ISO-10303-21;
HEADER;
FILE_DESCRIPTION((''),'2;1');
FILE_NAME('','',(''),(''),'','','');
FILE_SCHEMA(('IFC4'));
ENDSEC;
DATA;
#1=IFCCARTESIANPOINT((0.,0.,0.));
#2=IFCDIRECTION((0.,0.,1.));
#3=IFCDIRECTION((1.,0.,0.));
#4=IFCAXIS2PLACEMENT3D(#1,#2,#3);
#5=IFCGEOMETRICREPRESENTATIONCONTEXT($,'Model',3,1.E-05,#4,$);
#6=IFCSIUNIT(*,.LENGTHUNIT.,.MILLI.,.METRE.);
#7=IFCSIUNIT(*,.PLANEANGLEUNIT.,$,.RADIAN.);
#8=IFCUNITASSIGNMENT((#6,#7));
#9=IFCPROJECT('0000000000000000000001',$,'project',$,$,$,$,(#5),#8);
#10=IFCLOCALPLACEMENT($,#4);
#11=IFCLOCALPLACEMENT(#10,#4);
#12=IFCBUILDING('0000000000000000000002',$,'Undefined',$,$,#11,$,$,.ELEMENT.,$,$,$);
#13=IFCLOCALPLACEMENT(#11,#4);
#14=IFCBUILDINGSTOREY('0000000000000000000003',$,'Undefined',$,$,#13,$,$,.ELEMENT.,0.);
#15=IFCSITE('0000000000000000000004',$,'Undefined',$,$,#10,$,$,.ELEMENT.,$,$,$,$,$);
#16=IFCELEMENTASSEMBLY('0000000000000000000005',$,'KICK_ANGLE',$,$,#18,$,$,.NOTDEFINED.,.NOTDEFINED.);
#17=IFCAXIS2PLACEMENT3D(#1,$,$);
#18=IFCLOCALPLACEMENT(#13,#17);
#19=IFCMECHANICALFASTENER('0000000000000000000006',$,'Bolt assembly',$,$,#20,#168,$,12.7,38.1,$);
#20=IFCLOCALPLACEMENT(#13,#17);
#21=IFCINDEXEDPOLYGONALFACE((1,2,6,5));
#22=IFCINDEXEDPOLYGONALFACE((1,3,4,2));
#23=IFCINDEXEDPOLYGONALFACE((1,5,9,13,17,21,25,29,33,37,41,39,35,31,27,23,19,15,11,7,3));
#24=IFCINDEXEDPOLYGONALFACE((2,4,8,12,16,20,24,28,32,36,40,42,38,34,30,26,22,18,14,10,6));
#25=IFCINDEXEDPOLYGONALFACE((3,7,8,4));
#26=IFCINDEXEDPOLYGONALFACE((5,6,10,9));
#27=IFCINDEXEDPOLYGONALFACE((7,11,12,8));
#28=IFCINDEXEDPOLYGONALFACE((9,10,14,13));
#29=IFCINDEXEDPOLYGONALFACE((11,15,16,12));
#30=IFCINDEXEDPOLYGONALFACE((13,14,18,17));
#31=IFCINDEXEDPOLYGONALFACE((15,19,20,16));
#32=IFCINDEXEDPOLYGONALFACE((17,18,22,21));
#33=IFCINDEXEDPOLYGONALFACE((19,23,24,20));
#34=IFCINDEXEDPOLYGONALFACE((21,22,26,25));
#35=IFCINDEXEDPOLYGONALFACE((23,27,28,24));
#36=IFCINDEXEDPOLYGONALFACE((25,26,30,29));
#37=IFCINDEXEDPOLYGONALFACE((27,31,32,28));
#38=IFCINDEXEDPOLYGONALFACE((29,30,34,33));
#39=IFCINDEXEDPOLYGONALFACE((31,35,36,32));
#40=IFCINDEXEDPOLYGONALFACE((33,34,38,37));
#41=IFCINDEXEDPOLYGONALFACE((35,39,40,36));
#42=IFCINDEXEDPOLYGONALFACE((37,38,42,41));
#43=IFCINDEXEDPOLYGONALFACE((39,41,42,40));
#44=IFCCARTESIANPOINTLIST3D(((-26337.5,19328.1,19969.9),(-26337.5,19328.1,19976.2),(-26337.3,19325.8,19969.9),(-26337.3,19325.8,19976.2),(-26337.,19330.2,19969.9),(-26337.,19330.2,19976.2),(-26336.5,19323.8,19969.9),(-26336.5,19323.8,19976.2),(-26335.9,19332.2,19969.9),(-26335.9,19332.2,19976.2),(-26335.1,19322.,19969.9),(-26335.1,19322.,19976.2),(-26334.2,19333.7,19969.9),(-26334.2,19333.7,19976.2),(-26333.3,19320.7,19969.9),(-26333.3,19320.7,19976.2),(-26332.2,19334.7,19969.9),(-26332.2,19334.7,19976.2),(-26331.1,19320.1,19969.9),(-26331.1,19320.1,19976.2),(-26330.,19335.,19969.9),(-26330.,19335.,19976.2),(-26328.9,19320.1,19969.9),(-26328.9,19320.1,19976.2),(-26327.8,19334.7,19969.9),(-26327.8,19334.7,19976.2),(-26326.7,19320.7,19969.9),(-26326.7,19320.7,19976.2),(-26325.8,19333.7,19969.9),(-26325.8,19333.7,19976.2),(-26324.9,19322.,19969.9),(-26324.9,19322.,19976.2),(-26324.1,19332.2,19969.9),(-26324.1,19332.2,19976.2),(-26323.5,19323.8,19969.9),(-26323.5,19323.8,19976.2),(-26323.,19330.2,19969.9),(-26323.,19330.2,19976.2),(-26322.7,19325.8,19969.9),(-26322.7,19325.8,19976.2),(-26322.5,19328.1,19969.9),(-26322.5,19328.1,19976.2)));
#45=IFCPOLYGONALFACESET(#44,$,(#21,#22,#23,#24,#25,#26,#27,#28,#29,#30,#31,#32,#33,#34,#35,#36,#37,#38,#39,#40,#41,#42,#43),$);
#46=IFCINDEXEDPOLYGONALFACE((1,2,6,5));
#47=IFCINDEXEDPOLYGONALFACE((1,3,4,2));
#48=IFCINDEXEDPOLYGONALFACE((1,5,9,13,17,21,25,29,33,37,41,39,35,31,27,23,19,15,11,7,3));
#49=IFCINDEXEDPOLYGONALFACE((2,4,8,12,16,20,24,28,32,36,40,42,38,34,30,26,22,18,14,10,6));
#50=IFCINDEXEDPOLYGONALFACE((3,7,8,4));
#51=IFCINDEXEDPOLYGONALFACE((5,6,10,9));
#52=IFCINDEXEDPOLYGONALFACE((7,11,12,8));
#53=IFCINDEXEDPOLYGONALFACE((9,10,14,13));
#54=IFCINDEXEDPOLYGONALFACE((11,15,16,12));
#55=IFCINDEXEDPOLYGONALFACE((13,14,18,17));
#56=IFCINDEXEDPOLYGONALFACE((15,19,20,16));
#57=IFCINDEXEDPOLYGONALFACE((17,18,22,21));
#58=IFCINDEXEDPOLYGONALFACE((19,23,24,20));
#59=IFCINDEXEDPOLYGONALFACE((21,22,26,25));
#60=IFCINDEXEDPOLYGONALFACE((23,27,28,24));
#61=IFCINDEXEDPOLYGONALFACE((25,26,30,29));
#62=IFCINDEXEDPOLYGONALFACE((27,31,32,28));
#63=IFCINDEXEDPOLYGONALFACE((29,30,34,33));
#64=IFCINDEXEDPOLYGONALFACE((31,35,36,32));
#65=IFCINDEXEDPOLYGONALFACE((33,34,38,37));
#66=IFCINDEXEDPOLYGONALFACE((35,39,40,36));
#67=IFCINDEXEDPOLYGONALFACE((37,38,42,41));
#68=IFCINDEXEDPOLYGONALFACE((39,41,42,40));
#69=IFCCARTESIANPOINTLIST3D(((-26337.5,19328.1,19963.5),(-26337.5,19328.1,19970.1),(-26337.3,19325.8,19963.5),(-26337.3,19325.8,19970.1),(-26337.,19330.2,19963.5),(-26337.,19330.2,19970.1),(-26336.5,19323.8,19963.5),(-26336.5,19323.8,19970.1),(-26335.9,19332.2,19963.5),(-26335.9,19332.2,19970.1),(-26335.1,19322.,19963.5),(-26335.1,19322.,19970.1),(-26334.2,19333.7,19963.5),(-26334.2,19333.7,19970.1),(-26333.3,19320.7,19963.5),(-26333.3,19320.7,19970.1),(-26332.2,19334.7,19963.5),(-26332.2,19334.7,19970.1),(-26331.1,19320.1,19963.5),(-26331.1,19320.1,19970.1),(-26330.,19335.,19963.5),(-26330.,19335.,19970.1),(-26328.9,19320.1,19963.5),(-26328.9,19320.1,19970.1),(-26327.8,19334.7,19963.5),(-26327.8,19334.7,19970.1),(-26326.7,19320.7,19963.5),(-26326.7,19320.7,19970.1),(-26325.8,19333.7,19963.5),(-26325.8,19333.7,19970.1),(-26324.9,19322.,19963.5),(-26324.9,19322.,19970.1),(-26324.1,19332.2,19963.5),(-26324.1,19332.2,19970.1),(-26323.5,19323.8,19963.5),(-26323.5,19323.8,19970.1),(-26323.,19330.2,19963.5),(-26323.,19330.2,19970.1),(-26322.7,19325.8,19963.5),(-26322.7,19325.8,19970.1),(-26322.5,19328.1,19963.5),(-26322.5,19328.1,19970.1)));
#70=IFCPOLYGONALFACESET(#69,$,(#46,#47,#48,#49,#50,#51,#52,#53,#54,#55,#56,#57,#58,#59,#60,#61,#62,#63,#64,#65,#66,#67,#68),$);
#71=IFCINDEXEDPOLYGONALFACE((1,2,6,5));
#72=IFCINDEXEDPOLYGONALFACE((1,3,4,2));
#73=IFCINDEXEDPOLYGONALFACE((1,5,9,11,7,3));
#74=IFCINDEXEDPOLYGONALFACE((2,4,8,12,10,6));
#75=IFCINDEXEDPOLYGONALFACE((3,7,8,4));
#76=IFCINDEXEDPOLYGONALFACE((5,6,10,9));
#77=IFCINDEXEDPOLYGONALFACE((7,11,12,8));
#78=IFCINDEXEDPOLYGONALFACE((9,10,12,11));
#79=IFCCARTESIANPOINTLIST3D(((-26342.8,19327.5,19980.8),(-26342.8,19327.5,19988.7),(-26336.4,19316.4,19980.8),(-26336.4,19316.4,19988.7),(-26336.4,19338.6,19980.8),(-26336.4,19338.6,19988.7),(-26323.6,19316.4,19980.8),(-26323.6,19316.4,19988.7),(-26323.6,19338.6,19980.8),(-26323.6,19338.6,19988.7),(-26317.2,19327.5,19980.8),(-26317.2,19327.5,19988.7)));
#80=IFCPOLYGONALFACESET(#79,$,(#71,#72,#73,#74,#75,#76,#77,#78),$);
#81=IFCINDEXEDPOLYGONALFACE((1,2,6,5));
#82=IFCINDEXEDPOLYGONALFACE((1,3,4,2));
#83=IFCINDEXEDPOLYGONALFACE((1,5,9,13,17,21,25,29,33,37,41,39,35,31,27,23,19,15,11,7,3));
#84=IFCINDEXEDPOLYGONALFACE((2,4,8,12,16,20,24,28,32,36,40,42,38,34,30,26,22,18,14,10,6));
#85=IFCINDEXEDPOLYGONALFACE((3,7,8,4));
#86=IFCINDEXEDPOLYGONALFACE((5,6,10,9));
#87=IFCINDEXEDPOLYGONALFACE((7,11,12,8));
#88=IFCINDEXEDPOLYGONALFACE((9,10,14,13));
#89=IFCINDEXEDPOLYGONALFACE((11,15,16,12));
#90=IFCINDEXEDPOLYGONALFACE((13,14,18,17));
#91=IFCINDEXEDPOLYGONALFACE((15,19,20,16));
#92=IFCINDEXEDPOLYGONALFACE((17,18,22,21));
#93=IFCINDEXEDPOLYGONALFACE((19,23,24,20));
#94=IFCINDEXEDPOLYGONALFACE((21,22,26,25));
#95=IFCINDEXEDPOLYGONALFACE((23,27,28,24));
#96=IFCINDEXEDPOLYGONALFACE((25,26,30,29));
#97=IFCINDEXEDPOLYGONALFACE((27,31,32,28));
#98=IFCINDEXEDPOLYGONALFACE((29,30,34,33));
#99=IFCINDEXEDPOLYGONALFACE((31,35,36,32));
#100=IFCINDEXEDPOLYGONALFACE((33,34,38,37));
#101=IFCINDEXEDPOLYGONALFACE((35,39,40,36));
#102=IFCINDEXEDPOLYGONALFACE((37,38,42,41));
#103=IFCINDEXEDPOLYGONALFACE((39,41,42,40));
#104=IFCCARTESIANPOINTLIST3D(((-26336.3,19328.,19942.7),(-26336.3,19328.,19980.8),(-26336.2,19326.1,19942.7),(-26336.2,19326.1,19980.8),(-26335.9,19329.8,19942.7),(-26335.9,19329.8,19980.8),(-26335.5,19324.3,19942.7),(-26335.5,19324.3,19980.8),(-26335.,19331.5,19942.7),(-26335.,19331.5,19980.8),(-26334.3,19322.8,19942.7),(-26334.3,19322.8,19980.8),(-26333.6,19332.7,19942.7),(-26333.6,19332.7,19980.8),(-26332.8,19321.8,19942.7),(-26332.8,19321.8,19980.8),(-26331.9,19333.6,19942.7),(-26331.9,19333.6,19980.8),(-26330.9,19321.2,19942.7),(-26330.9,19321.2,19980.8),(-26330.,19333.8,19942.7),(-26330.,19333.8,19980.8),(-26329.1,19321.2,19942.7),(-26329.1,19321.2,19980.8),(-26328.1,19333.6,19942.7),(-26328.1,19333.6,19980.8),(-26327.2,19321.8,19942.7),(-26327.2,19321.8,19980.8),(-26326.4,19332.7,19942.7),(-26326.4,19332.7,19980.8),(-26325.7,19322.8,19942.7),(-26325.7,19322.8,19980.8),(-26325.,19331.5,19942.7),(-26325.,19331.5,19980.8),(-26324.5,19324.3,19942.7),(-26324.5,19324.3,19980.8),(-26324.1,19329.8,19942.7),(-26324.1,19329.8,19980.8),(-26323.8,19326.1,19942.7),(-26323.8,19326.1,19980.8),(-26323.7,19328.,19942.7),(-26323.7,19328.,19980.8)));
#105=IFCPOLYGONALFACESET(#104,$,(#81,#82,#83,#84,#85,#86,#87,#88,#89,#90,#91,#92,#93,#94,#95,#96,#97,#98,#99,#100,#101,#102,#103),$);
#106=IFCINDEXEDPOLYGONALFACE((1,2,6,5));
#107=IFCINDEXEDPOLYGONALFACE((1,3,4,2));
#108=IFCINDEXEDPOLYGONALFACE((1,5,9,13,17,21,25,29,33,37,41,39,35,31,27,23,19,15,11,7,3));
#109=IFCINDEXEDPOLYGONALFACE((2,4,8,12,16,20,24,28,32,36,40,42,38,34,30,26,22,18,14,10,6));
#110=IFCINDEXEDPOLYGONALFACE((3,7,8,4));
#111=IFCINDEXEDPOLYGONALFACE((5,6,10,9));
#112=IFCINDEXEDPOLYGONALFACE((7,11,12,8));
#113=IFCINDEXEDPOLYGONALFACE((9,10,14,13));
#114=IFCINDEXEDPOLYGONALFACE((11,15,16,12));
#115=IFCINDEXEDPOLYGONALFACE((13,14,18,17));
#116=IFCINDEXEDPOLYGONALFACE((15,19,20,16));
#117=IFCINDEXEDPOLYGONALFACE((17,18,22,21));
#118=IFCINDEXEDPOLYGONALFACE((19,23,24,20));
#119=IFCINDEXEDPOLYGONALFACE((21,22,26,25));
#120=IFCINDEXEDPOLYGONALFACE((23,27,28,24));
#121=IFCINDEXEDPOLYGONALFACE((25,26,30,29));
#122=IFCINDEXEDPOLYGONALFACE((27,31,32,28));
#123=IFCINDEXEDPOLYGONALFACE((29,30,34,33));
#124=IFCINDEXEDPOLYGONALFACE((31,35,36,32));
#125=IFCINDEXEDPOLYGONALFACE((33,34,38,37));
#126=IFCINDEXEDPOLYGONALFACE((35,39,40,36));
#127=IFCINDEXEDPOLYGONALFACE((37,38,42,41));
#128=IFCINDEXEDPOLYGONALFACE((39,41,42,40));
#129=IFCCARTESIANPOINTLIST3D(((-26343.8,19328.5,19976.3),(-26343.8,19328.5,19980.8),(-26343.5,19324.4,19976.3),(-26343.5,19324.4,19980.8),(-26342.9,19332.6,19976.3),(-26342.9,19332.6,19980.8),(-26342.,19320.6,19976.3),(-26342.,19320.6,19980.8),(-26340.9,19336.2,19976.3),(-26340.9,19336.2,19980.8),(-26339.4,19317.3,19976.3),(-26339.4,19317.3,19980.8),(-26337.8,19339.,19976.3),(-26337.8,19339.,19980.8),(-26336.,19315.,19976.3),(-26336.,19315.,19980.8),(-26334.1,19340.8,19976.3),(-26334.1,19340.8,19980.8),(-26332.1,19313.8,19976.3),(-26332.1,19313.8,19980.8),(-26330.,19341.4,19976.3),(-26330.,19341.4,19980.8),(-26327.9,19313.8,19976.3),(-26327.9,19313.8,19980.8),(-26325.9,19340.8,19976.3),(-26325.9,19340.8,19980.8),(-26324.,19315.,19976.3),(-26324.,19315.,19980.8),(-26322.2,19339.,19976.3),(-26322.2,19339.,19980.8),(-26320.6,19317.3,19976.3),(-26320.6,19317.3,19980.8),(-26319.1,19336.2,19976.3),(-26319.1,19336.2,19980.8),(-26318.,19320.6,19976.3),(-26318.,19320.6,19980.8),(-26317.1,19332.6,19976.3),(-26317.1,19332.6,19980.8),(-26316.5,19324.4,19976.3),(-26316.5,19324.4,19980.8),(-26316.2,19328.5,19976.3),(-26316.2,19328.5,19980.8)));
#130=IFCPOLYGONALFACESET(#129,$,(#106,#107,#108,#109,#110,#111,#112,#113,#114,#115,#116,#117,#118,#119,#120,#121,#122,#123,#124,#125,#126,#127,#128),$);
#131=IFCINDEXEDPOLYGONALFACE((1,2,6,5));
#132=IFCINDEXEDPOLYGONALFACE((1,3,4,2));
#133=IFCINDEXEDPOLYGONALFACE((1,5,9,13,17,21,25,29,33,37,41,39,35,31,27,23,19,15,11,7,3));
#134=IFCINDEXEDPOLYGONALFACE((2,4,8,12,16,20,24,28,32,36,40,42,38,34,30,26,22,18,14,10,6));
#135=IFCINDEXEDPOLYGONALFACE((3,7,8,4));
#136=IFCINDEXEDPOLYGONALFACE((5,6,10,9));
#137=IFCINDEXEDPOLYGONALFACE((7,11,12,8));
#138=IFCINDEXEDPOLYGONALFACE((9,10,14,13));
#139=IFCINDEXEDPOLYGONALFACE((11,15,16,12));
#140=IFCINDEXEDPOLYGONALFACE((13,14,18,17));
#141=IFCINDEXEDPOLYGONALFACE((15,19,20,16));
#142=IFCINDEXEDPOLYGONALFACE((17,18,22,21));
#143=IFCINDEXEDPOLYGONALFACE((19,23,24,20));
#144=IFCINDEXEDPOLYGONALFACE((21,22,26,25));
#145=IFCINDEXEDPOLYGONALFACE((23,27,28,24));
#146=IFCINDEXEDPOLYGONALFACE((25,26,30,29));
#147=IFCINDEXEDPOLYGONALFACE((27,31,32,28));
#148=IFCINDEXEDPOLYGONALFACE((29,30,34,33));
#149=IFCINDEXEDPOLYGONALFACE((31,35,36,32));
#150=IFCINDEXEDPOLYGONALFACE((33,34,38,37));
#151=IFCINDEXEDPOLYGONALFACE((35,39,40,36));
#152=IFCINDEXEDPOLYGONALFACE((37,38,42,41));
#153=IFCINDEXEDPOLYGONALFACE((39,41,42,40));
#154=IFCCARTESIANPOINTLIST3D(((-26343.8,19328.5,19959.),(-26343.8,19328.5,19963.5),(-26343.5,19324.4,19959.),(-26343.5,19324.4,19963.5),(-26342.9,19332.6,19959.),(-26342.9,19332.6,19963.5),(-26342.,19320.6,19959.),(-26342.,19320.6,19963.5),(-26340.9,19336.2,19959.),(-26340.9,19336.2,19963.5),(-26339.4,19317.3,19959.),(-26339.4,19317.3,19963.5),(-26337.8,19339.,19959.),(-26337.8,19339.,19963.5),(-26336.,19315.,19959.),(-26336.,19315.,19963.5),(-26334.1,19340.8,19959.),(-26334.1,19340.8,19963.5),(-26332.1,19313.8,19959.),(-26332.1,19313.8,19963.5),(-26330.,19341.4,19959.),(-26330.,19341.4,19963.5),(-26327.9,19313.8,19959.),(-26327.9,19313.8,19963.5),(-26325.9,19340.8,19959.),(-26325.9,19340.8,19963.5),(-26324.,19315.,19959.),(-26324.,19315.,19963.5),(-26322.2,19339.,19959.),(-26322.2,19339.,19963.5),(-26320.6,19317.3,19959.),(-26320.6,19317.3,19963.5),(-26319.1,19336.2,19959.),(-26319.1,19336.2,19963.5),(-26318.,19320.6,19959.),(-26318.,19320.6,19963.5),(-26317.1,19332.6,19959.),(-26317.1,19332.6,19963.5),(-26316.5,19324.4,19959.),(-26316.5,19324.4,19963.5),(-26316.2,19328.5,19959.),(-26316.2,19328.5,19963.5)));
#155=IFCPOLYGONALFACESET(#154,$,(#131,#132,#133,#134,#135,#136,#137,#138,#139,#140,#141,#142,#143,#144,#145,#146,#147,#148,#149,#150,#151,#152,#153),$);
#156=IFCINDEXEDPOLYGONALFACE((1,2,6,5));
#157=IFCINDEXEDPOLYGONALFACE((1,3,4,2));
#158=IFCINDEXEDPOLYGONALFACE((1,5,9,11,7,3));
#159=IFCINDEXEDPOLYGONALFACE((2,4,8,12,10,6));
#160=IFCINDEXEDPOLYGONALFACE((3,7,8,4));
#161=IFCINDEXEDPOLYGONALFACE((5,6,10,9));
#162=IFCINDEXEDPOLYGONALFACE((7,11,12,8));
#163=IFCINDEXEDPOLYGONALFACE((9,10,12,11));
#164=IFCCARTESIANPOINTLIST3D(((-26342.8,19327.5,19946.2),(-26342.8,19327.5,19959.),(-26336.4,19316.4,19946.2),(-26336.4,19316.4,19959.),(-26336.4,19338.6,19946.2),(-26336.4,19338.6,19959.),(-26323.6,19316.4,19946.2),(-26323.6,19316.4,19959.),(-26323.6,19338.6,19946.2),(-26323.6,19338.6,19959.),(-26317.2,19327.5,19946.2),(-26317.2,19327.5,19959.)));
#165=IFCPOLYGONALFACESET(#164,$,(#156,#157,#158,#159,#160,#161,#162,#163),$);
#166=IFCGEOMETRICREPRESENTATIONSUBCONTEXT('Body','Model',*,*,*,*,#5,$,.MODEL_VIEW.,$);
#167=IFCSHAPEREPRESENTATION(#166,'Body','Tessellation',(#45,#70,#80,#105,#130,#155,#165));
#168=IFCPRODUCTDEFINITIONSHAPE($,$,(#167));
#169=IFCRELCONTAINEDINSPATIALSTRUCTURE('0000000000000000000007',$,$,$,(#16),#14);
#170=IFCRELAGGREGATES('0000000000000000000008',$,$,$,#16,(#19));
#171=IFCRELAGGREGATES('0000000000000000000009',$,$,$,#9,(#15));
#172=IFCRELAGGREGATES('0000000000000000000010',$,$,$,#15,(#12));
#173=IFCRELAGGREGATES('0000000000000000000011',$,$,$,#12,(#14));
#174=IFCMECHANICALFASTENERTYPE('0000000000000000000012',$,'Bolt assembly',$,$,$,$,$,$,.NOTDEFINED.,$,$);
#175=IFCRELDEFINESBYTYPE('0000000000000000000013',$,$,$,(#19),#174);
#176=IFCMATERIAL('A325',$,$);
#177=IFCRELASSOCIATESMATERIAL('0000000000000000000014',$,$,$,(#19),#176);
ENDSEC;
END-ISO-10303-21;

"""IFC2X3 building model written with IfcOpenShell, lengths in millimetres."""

from ifc_helpers import new_model, si_unit, frame, origin_with_axes, origin_2d_with_axis, place, context, subcontext, project, spatial, polyline, circle, outline, extrude, source, transform, mapped, material, type_object, element, aggregate, save


model = new_model("IFC2X3")

# Units and contexts
model_context = context("Model", 3, precision=1e-05, world=origin_with_axes())
body_context = subcontext(model_context, "Body", "Model", "MODEL_VIEW")
ifc_project = project(units=[si_unit("LENGTHUNIT", "METRE", prefix="MILLI"), si_unit("PLANEANGLEUNIT", "RADIAN")], contexts=[model_context])

# Site, building, storey
site_placement = place(None, origin_with_axes())
site = spatial("IfcSite", under=ifc_project, at=site_placement, Name="Undefined", CompositionType="ELEMENT")
building_placement = place(site_placement, origin_with_axes())
building = spatial("IfcBuilding", under=site, at=building_placement, Name="Undefined", CompositionType="ELEMENT")
storey_placement = place(building_placement, origin_with_axes())
storey = spatial("IfcBuildingStorey", under=building, at=storey_placement, Name="Undefined", CompositionType="ELEMENT", Elevation=0.0)

# Element assembly
assembly_1_placement = place(storey_placement, origin_with_axes())
assembly_1 = element("IfcElementAssembly", 1, at=assembly_1_placement, inside=storey, Name="KICK_ANGLE", AssemblyPlace="NOTDEFINED", PredefinedType="NOTDEFINED")

# Shared definitions
ifc_material_1 = material(Name="A325")
mechanical_fastener_type = type_object("IfcMechanicalFastenerType", Name="Bolt assembly")

# Mechanical fastener
shared_shape_1 = source(origin_with_axes(), body_context, "Body", "SweptSolid", [
    extrude(circle(Radius=7.5, at=origin_2d_with_axis()), frame((0.0, -6.2, 0.0), z_axis=(0.0, 1.0, 0.0), x_axis=(1.0, 0.0, 0.0)), (0.0, 0.0, 1.0), 6.3),
    extrude(circle(Radius=7.5, at=origin_2d_with_axis()), frame((0.0, -0.1, 0.0), z_axis=(0.0, 1.0, 0.0), x_axis=(1.0, 0.0, 0.0)), (0.0, 0.0, 1.0), 6.6),
    extrude(outline(polyline([(11.1, -6.4), (11.1, 6.4), (0.0, 12.8), (-11.1, 6.4), (-11.1, -6.4), (0.0, -12.8), (11.1, -6.4)])), frame((0.0, -18.7, 0.0), z_axis=(0.0, 1.0, 0.0), x_axis=(1.0, 0.0, 0.0)), (0.0, 0.0, 1.0), 7.9),
    extrude(circle(Radius=6.3, at=origin_2d_with_axis()), frame((0.0, -10.8, 0.0), z_axis=(0.0, 1.0, 0.0), x_axis=(1.0, 0.0, 0.0)), (0.0, 0.0, 1.0), 38.1),
    extrude(circle(Radius=13.9, at=origin_2d_with_axis()), frame((0.0, -10.8, 0.0), z_axis=(0.0, 1.0, 0.0), x_axis=(1.0, 0.0, 0.0)), (0.0, 0.0, 1.0), 4.5),
    extrude(circle(Radius=13.9, at=origin_2d_with_axis()), frame((0.0, 6.5, 0.0), z_axis=(0.0, 1.0, 0.0), x_axis=(1.0, 0.0, 0.0)), (0.0, 0.0, 1.0), 4.5),
    extrude(outline(polyline([(11.1, -6.4), (11.1, 6.4), (0.0, 12.8), (-11.1, 6.4), (-11.1, -6.4), (0.0, -12.8), (11.1, -6.4)])), frame((0.0, 11.0, 0.0), z_axis=(0.0, 1.0, 0.0), x_axis=(1.0, 0.0, 0.0)), (0.0, 0.0, 1.0), 12.8),
])
mechanical_fastener_1_placement = place(assembly_1_placement, frame((-26330.0, 19300.0, 19970.0), z_axis=(-1.0, 0.0, 0.0), x_axis=(0.0, 1.0, 0.0)))
mechanical_fastener_1 = element("IfcMechanicalFastener", 2, at=mechanical_fastener_1_placement, type_object=mechanical_fastener_type, material=ifc_material_1, Name="Bolt assembly", NominalDiameter=12.7, NominalLength=38.1, context=body_context, shape_type="MappedRepresentation", body=[
    mapped(shared_shape_1, transform((27.5, 0.0, 0.0))),
])
aggregate(assembly_1, [mechanical_fastener_1])

save(model, "model.ifc")
